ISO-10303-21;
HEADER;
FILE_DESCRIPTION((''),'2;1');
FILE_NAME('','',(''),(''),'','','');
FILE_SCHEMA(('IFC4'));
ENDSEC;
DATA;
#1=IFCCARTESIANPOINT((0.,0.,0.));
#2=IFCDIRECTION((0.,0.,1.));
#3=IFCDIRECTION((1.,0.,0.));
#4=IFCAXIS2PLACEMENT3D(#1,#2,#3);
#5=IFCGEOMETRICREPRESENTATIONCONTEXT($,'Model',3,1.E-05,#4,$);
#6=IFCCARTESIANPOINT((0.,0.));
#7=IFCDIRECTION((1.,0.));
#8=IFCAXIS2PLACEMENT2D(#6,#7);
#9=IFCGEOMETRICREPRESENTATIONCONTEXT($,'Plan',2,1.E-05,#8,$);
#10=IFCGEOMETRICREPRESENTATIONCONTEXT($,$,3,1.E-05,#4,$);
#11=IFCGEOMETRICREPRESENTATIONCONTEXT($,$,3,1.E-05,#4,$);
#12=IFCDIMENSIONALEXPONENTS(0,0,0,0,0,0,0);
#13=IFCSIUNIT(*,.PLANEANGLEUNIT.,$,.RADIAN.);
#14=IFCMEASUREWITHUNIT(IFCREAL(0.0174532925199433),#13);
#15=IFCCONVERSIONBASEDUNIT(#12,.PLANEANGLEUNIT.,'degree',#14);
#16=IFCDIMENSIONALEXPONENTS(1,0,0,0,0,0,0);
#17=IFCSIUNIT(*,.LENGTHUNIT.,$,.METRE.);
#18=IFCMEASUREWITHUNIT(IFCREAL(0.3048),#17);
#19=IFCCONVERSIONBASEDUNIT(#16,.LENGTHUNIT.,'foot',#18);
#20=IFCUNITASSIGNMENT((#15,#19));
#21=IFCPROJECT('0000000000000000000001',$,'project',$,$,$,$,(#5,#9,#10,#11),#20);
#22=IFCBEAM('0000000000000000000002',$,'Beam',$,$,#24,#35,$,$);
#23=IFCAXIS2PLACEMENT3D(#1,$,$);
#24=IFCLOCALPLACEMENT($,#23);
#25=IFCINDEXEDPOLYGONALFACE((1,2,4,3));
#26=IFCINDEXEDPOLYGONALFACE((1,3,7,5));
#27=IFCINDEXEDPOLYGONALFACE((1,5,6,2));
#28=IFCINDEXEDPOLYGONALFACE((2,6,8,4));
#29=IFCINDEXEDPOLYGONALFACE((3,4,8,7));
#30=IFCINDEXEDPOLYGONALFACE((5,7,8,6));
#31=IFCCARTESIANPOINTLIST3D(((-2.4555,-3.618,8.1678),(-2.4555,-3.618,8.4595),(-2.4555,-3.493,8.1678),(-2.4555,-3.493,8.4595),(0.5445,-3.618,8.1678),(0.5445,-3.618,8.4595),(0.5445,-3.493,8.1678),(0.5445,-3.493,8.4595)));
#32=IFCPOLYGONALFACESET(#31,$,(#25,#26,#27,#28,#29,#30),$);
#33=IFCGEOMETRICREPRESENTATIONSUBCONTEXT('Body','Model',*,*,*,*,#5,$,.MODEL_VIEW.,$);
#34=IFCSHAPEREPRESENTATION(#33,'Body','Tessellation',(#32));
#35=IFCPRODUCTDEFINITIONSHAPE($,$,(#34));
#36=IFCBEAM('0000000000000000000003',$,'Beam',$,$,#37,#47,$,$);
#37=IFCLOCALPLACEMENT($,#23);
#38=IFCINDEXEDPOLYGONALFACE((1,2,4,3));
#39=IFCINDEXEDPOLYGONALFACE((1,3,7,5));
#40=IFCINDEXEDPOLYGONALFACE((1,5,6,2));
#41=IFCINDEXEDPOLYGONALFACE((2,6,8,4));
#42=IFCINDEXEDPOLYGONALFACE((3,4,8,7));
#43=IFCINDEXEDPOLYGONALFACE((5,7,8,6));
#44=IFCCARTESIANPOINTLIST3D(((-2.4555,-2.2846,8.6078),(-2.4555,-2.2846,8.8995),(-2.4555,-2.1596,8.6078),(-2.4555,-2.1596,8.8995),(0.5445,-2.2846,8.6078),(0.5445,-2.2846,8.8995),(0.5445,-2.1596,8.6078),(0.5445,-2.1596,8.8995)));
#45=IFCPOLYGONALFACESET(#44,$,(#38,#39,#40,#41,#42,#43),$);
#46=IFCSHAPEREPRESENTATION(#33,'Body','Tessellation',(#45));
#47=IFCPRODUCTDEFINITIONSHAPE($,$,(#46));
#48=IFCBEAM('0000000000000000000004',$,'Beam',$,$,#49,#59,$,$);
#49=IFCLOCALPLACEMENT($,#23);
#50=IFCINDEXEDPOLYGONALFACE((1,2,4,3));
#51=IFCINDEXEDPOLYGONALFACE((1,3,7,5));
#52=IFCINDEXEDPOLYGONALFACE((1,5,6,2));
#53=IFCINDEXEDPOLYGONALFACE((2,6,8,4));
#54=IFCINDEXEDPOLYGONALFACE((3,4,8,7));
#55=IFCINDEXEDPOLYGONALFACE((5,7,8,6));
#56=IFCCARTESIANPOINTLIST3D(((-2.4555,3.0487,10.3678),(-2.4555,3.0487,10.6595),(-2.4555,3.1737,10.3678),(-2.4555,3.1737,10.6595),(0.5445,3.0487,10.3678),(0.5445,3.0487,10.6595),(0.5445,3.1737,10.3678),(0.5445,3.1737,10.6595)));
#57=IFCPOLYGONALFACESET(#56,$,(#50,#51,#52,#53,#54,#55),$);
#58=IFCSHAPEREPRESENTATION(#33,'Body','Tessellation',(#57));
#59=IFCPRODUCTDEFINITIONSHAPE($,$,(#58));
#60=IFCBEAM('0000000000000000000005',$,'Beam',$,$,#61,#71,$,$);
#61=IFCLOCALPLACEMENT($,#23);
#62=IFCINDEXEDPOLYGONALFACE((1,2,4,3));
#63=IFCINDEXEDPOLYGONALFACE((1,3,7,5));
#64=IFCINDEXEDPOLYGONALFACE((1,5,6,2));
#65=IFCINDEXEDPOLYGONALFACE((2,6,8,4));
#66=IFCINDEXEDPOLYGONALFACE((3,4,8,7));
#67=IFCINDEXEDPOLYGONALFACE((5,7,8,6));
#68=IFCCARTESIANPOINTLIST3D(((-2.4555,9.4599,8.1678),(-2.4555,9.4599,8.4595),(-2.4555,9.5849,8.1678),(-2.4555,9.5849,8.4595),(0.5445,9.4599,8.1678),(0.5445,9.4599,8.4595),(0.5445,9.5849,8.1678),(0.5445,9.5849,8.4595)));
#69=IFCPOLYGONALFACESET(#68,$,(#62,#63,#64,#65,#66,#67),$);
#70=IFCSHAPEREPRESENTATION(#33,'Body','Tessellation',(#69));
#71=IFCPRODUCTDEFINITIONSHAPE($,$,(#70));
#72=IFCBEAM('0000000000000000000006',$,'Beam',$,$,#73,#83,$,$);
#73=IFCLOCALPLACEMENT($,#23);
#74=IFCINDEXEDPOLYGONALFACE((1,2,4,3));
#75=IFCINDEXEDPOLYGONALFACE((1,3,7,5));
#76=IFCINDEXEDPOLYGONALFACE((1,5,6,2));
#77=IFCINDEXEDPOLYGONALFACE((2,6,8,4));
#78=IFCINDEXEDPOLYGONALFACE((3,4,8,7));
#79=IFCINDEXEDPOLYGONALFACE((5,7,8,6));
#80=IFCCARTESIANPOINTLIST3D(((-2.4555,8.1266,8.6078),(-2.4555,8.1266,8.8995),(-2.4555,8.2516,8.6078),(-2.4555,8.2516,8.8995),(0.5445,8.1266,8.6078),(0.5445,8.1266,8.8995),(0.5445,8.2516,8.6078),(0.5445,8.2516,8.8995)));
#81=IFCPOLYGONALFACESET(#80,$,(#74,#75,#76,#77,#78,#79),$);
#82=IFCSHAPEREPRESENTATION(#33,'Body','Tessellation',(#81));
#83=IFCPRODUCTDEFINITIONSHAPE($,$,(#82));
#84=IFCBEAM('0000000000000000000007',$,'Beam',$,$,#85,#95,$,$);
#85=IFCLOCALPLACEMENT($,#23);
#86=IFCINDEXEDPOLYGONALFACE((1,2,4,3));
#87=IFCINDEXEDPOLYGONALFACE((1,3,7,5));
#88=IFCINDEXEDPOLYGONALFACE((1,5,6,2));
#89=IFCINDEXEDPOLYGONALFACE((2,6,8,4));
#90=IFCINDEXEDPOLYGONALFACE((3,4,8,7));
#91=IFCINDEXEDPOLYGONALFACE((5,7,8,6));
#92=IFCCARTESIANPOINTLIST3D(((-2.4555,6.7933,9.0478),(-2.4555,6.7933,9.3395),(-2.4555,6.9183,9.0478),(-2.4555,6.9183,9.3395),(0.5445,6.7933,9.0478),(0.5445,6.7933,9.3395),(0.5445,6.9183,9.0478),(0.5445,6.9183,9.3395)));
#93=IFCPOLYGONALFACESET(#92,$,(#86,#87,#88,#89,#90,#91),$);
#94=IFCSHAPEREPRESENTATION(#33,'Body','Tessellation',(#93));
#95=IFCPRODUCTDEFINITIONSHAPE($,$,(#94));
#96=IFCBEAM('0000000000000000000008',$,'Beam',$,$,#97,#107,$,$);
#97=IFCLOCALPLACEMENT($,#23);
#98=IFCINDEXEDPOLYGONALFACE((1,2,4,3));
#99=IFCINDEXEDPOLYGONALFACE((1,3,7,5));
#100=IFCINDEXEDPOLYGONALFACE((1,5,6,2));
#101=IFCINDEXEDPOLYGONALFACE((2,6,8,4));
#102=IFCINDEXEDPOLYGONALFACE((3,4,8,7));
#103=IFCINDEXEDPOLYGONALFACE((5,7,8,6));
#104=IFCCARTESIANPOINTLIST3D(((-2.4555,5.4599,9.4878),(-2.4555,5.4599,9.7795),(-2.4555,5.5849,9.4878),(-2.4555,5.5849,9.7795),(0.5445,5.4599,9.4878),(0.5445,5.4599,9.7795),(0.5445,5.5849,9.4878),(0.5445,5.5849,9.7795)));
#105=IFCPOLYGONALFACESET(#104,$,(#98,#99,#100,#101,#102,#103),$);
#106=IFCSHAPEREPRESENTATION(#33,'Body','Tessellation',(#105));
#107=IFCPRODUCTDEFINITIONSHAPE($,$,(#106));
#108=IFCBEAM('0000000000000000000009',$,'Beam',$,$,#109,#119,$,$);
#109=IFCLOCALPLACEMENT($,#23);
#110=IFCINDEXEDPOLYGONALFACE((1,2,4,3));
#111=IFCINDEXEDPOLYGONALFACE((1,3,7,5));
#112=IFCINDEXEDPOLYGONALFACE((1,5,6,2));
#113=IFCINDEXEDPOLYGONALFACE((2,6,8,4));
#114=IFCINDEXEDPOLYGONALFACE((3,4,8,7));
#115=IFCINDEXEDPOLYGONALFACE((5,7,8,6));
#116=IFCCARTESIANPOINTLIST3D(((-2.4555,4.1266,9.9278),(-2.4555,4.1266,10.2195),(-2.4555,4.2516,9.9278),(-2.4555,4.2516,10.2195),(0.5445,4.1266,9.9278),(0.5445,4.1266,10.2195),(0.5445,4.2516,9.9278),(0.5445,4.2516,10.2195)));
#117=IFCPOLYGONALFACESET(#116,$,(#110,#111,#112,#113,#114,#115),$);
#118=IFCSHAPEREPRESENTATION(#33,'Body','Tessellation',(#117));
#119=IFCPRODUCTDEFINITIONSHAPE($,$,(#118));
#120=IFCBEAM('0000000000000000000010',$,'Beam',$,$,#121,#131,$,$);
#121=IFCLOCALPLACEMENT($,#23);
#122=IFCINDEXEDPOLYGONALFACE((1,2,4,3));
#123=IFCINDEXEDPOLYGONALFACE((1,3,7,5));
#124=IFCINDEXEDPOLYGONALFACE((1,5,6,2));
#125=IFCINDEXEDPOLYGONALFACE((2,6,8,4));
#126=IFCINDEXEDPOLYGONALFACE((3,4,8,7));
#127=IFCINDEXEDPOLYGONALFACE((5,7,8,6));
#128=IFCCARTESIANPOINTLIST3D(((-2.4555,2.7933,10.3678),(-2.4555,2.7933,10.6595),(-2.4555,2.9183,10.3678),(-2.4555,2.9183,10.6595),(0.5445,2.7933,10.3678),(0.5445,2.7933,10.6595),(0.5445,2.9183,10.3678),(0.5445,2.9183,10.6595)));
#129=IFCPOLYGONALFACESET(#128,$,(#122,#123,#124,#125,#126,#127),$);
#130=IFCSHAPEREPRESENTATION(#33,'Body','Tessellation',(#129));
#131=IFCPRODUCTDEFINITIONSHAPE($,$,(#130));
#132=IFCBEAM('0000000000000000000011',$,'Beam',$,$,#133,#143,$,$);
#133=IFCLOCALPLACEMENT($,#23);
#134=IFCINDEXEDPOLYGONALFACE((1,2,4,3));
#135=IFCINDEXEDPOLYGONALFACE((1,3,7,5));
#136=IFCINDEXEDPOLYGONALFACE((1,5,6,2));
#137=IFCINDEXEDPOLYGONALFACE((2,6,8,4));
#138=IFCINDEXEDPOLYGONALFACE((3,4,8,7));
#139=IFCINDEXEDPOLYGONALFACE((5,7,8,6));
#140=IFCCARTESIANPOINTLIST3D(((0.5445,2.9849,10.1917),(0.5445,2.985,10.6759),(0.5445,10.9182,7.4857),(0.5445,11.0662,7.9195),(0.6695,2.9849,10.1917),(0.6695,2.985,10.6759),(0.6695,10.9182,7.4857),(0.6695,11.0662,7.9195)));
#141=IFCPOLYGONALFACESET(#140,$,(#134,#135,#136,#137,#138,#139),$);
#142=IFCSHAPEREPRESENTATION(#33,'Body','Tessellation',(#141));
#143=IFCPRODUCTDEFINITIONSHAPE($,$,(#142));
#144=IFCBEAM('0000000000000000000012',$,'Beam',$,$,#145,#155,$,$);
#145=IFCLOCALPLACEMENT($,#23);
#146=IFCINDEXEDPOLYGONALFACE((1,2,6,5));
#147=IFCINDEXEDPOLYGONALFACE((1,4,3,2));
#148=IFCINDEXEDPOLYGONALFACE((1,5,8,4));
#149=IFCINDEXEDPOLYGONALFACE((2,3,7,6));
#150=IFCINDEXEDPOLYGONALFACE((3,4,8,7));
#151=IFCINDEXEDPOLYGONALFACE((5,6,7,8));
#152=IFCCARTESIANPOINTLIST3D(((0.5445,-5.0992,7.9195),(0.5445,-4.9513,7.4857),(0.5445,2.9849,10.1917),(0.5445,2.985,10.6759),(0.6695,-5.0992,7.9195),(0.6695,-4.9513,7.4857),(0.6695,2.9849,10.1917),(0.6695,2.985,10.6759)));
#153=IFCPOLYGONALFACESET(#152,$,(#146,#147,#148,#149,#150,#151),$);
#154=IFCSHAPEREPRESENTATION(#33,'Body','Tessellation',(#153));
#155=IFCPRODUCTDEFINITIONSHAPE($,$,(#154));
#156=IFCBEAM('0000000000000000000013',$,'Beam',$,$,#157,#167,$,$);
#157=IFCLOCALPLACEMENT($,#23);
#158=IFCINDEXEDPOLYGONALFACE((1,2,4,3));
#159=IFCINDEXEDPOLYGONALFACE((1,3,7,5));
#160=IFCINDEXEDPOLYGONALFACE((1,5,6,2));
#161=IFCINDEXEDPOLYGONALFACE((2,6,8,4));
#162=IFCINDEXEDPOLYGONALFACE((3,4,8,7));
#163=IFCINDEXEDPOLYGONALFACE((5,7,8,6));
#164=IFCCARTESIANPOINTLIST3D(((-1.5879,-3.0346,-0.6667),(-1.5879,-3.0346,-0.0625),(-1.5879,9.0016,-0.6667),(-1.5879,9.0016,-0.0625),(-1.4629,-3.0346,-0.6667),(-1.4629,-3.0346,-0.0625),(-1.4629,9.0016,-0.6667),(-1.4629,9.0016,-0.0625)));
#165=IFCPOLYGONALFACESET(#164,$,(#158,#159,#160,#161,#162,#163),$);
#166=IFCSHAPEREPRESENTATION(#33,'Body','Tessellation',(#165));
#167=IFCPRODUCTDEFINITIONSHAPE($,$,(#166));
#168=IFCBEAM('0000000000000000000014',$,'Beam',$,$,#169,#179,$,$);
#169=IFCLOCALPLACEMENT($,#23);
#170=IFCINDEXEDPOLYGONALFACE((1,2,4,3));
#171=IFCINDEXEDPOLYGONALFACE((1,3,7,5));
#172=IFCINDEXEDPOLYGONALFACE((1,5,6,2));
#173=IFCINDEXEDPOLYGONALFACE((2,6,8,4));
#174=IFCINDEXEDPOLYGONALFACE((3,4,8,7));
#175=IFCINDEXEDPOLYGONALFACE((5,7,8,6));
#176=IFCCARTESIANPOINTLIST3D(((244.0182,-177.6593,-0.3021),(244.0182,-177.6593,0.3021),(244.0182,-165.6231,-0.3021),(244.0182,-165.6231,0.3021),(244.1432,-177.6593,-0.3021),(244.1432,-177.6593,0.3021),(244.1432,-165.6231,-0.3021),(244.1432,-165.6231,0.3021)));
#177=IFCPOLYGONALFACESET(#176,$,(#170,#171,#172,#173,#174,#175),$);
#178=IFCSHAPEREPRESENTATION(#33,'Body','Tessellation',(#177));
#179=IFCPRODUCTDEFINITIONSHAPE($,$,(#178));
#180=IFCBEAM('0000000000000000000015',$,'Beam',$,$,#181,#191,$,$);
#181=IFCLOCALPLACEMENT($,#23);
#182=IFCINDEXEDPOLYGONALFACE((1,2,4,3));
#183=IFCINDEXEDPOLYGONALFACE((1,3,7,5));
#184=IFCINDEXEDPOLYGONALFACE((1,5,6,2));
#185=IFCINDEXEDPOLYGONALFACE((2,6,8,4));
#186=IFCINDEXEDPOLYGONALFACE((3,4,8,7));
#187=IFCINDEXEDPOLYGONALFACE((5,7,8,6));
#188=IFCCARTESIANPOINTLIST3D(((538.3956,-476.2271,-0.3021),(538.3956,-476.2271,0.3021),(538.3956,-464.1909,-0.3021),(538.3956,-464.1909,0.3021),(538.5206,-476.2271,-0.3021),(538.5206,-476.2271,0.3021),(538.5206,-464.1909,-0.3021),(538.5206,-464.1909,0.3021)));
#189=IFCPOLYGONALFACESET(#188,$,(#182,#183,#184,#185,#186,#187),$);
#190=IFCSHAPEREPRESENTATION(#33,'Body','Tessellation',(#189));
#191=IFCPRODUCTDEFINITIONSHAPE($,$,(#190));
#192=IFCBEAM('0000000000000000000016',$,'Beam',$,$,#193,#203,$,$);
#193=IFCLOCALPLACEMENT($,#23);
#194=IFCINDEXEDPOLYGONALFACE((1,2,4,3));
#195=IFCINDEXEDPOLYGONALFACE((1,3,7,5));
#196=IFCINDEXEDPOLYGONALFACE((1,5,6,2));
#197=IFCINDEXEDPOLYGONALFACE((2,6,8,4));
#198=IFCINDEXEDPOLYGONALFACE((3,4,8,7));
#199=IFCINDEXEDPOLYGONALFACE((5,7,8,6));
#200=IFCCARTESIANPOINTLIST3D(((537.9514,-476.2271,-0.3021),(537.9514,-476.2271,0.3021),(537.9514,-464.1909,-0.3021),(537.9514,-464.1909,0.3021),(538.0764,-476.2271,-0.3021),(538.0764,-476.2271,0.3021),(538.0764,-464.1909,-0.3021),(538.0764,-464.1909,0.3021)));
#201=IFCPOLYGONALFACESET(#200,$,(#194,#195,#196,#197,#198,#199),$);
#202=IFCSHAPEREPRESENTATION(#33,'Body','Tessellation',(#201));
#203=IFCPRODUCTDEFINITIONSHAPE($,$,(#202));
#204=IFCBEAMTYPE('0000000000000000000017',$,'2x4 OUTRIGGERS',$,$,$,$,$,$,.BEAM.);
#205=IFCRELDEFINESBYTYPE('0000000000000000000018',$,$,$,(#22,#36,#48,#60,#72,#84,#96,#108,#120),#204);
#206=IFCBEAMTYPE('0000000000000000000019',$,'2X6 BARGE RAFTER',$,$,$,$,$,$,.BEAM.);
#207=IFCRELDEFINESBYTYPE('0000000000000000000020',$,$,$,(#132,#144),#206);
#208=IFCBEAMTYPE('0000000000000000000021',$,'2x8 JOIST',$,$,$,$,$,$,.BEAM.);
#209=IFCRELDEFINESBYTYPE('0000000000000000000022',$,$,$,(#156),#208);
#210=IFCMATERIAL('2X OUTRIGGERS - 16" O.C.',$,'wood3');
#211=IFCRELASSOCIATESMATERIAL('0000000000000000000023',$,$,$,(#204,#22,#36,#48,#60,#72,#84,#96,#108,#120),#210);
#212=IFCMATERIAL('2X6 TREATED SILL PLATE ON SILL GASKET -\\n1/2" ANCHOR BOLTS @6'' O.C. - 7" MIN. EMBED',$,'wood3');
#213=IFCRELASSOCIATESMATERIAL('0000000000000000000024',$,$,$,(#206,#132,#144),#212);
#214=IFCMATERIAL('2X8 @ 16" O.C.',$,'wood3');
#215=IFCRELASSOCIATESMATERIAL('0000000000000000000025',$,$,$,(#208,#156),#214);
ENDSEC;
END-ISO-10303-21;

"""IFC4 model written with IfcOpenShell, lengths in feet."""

from ifc_helpers import new_model, entity, si_unit, converted_unit, frame, origin_with_axes, origin_2d_with_axis, place, context, subcontext, project, rectangle, extrude, clip, halfspace, material, material_profile, profile_set, profile_usage, type_object, element, save


model = new_model("IFC4")

# Units and contexts
model_context = context("Model", 3, precision=1e-05, world=origin_with_axes())
plan_context = context("Plan", 2, precision=1e-05, world=origin_2d_with_axis())
context_of_model_1 = context(None, 3, precision=1e-05, world=origin_with_axes())
context_of_model_2 = context(None, 3, precision=1e-05, world=origin_with_axes())
body_context = subcontext(model_context, "Body", "Model", "MODEL_VIEW")
ifc_project = project(units=[converted_unit("PLANEANGLEUNIT", "degree", entity("IfcReal", 0.0174532925199433), si_unit("PLANEANGLEUNIT", "RADIAN"), dimensions=[0, 0, 0, 0, 0, 0, 0]), converted_unit("LENGTHUNIT", "foot", entity("IfcReal", 0.3048), si_unit("LENGTHUNIT", "METRE"), dimensions=[1, 0, 0, 0, 0, 0, 0])], contexts=[model_context, plan_context, context_of_model_1, context_of_model_2])

# Beams
ifc_material_1 = material(Name="2X OUTRIGGERS - 16\" O.C.", Category="wood3")
ifc_material_profile_1 = material_profile(ifc_material_1, rectangle(XDim=0.125, YDim=0.2917))
ifc_profile_set_1 = profile_set([ifc_material_profile_1])
ifc_profile_usage_1 = profile_usage(ifc_profile_set_1, cardinal=5)
beam_type_1 = type_object("IfcBeamType", Name="2x4 OUTRIGGERS", PredefinedType="BEAM", material=ifc_profile_set_1)
beam_1_placement = place(None, frame((-2.4555, -3.5555, 8.3137), z_axis=(1.0, 0.0, 0.0), x_axis=(0.0, 1.0, 0.0)))
element("IfcBeam", 1, at=beam_1_placement, type_object=beam_type_1, material=ifc_profile_usage_1, Name="Beam", context=body_context, shape_type="SweptSolid", body=[
    extrude(rectangle(XDim=0.125, YDim=0.2917), origin_with_axes(), (0.0, 0.0, 1.0), 3.0),
])
ifc_profile_usage_2 = profile_usage(ifc_profile_set_1, cardinal=5)
beam_2_placement = place(None, frame((-2.4555, -2.2221, 8.7537), z_axis=(1.0, 0.0, 0.0), x_axis=(0.0, 1.0, 0.0)))
element("IfcBeam", 2, at=beam_2_placement, type_object=beam_type_1, material=ifc_profile_usage_2, Name="Beam", context=body_context, shape_type="SweptSolid", body=[
    extrude(rectangle(XDim=0.125, YDim=0.2917), origin_with_axes(), (0.0, 0.0, 1.0), 3.0),
])
ifc_profile_usage_3 = profile_usage(ifc_profile_set_1, cardinal=5)
beam_3_placement = place(None, frame((-2.4555, 3.1112, 10.5137), z_axis=(1.0, 0.0, 0.0), x_axis=(0.0, 1.0, 0.0)))
element("IfcBeam", 3, at=beam_3_placement, type_object=beam_type_1, material=ifc_profile_usage_3, Name="Beam", context=body_context, shape_type="SweptSolid", body=[
    extrude(rectangle(XDim=0.125, YDim=0.2917), origin_with_axes(), (0.0, 0.0, 1.0), 3.0),
])
ifc_profile_usage_4 = profile_usage(ifc_profile_set_1, cardinal=5)
beam_4_placement = place(None, frame((-2.4555, 9.5224, 8.3137), z_axis=(1.0, 0.0, 0.0), x_axis=(0.0, 1.0, 0.0)))
element("IfcBeam", 4, at=beam_4_placement, type_object=beam_type_1, material=ifc_profile_usage_4, Name="Beam", context=body_context, shape_type="SweptSolid", body=[
    extrude(rectangle(XDim=0.125, YDim=0.2917), origin_with_axes(), (0.0, 0.0, 1.0), 3.0),
])
ifc_profile_usage_5 = profile_usage(ifc_profile_set_1, cardinal=5)
beam_5_placement = place(None, frame((-2.4555, 8.1891, 8.7537), z_axis=(1.0, 0.0, 0.0), x_axis=(0.0, 1.0, 0.0)))
element("IfcBeam", 5, at=beam_5_placement, type_object=beam_type_1, material=ifc_profile_usage_5, Name="Beam", context=body_context, shape_type="SweptSolid", body=[
    extrude(rectangle(XDim=0.125, YDim=0.2917), origin_with_axes(), (0.0, 0.0, 1.0), 3.0),
])
ifc_profile_usage_6 = profile_usage(ifc_profile_set_1, cardinal=5)
beam_6_placement = place(None, frame((-2.4555, 6.8558, 9.1937), z_axis=(1.0, 0.0, 0.0), x_axis=(0.0, 1.0, 0.0)))
element("IfcBeam", 6, at=beam_6_placement, type_object=beam_type_1, material=ifc_profile_usage_6, Name="Beam", context=body_context, shape_type="SweptSolid", body=[
    extrude(rectangle(XDim=0.125, YDim=0.2917), origin_with_axes(), (0.0, 0.0, 1.0), 3.0),
])
ifc_profile_usage_7 = profile_usage(ifc_profile_set_1, cardinal=5)
beam_7_placement = place(None, frame((-2.4555, 5.5224, 9.6337), z_axis=(1.0, 0.0, 0.0), x_axis=(0.0, 1.0, 0.0)))
element("IfcBeam", 7, at=beam_7_placement, type_object=beam_type_1, material=ifc_profile_usage_7, Name="Beam", context=body_context, shape_type="SweptSolid", body=[
    extrude(rectangle(XDim=0.125, YDim=0.2917), origin_with_axes(), (0.0, 0.0, 1.0), 3.0),
])
ifc_profile_usage_8 = profile_usage(ifc_profile_set_1, cardinal=5)
beam_8_placement = place(None, frame((-2.4555, 4.1891, 10.0737), z_axis=(1.0, 0.0, 0.0), x_axis=(0.0, 1.0, 0.0)))
element("IfcBeam", 8, at=beam_8_placement, type_object=beam_type_1, material=ifc_profile_usage_8, Name="Beam", context=body_context, shape_type="SweptSolid", body=[
    extrude(rectangle(XDim=0.125, YDim=0.2917), origin_with_axes(), (0.0, 0.0, 1.0), 3.0),
])
ifc_profile_usage_9 = profile_usage(ifc_profile_set_1, cardinal=5)
beam_9_placement = place(None, frame((-2.4555, 2.8558, 10.5137), z_axis=(1.0, 0.0, 0.0), x_axis=(0.0, 1.0, 0.0)))
element("IfcBeam", 9, at=beam_9_placement, type_object=beam_type_1, material=ifc_profile_usage_9, Name="Beam", context=body_context, shape_type="SweptSolid", body=[
    extrude(rectangle(XDim=0.125, YDim=0.2917), origin_with_axes(), (0.0, 0.0, 1.0), 3.0),
])
ifc_material_2 = material(Name="2X6 TREATED SILL PLATE ON SILL GASKET -\\n1/2\" ANCHOR BOLTS @6' O.C. - 7\" MIN. EMBED", Category="wood3")
ifc_material_profile_2 = material_profile(ifc_material_2, rectangle(XDim=0.125, YDim=0.4583))
ifc_profile_set_2 = profile_set([ifc_material_profile_2])
ifc_profile_usage_10 = profile_usage(ifc_profile_set_2, cardinal=5)
beam_type_2 = type_object("IfcBeamType", Name="2X6 BARGE RAFTER", PredefinedType="BEAM", material=ifc_profile_set_2)
beam_10_placement = place(None, frame((0.607, 10.9922, 7.7026), z_axis=(0.0, -0.946459, 0.322824), x_axis=(1.0, 0.0, 0.0)))
element("IfcBeam", 10, at=beam_10_placement, type_object=beam_type_2, material=ifc_profile_usage_10, Name="Beam", context=body_context, shape_type="Clipping", body=[
    clip(extrude(rectangle(XDim=0.125, YDim=0.4583), origin_with_axes(), (0.0, 0.0, 1.0), 9.2936), halfspace(frame((-0.607, 0.2291, 8.5384), z_axis=(0.0, -0.322771, 0.946477), x_axis=(-1.0, 0.000001, 0.0)), False)),
])
ifc_profile_usage_11 = profile_usage(ifc_profile_set_2, cardinal=5)
beam_11_placement = place(None, frame((0.607, -5.0252, 7.7026), z_axis=(0.000001, 0.946496, 0.322716), x_axis=(-1.0, 0.000001, 0.0)))
element("IfcBeam", 11, at=beam_11_placement, type_object=beam_type_2, material=ifc_profile_usage_11, Name="Beam", context=body_context, shape_type="Clipping", body=[
    clip(extrude(rectangle(XDim=0.125, YDim=0.4583), origin_with_axes(), (0.0, 0.0, 1.0), 9.2963), halfspace(frame((0.607, 0.2291, 8.5411), z_axis=(0.000001, -0.322769, 0.946478), x_axis=(-1.0, -0.000002, 0.0)), False)),
])
ifc_material_3 = material(Name="2X8 @ 16\" O.C.", Category="wood3")
ifc_material_profile_3 = material_profile(ifc_material_3, rectangle(XDim=0.125, YDim=0.6042))
ifc_profile_set_3 = profile_set([ifc_material_profile_3])
ifc_profile_usage_12 = profile_usage(ifc_profile_set_3, cardinal=5)
beam_type_3 = type_object("IfcBeamType", Name="2x8 JOIST", PredefinedType="BEAM", material=ifc_profile_set_3)
beam_12_placement = place(None, frame((-1.5254, -3.0346, -0.3646), z_axis=(0.0, 1.0, 0.0), x_axis=(-1.0, 0.0, 0.0)))
element("IfcBeam", 12, at=beam_12_placement, type_object=beam_type_3, material=ifc_profile_usage_12, Name="Beam", context=body_context, shape_type="SweptSolid", body=[
    extrude(rectangle(XDim=0.125, YDim=0.6042), origin_with_axes(), (0.0, 0.0, 1.0), 12.0362),
])
for number, where, z_axis, x_axis, name in (
    (13, (244.0807, -177.6593, 0.0), (0.0, 1.0, 0.0), (-1.0, 0.0, 0.0), "Beam"),
    (14, (538.4581, -476.2271, 0.0), (0.0, 1.0, 0.0), (-1.0, 0.0, 0.0), "Beam"),
    (15, (538.0139, -476.2271, 0.0), (0.0, 1.0, 0.0), (-1.0, 0.0, 0.0), "Beam"),
):
    element("IfcBeam", number, at=place(None, frame(where, z_axis=z_axis, x_axis=x_axis)), Name=name, context=body_context, shape_type="SweptSolid", body=[
        extrude(rectangle(XDim=0.125, YDim=0.6042), origin_with_axes(), (0.0, 0.0, 1.0), 12.0362),
    ])

save(model, "model.ifc")
